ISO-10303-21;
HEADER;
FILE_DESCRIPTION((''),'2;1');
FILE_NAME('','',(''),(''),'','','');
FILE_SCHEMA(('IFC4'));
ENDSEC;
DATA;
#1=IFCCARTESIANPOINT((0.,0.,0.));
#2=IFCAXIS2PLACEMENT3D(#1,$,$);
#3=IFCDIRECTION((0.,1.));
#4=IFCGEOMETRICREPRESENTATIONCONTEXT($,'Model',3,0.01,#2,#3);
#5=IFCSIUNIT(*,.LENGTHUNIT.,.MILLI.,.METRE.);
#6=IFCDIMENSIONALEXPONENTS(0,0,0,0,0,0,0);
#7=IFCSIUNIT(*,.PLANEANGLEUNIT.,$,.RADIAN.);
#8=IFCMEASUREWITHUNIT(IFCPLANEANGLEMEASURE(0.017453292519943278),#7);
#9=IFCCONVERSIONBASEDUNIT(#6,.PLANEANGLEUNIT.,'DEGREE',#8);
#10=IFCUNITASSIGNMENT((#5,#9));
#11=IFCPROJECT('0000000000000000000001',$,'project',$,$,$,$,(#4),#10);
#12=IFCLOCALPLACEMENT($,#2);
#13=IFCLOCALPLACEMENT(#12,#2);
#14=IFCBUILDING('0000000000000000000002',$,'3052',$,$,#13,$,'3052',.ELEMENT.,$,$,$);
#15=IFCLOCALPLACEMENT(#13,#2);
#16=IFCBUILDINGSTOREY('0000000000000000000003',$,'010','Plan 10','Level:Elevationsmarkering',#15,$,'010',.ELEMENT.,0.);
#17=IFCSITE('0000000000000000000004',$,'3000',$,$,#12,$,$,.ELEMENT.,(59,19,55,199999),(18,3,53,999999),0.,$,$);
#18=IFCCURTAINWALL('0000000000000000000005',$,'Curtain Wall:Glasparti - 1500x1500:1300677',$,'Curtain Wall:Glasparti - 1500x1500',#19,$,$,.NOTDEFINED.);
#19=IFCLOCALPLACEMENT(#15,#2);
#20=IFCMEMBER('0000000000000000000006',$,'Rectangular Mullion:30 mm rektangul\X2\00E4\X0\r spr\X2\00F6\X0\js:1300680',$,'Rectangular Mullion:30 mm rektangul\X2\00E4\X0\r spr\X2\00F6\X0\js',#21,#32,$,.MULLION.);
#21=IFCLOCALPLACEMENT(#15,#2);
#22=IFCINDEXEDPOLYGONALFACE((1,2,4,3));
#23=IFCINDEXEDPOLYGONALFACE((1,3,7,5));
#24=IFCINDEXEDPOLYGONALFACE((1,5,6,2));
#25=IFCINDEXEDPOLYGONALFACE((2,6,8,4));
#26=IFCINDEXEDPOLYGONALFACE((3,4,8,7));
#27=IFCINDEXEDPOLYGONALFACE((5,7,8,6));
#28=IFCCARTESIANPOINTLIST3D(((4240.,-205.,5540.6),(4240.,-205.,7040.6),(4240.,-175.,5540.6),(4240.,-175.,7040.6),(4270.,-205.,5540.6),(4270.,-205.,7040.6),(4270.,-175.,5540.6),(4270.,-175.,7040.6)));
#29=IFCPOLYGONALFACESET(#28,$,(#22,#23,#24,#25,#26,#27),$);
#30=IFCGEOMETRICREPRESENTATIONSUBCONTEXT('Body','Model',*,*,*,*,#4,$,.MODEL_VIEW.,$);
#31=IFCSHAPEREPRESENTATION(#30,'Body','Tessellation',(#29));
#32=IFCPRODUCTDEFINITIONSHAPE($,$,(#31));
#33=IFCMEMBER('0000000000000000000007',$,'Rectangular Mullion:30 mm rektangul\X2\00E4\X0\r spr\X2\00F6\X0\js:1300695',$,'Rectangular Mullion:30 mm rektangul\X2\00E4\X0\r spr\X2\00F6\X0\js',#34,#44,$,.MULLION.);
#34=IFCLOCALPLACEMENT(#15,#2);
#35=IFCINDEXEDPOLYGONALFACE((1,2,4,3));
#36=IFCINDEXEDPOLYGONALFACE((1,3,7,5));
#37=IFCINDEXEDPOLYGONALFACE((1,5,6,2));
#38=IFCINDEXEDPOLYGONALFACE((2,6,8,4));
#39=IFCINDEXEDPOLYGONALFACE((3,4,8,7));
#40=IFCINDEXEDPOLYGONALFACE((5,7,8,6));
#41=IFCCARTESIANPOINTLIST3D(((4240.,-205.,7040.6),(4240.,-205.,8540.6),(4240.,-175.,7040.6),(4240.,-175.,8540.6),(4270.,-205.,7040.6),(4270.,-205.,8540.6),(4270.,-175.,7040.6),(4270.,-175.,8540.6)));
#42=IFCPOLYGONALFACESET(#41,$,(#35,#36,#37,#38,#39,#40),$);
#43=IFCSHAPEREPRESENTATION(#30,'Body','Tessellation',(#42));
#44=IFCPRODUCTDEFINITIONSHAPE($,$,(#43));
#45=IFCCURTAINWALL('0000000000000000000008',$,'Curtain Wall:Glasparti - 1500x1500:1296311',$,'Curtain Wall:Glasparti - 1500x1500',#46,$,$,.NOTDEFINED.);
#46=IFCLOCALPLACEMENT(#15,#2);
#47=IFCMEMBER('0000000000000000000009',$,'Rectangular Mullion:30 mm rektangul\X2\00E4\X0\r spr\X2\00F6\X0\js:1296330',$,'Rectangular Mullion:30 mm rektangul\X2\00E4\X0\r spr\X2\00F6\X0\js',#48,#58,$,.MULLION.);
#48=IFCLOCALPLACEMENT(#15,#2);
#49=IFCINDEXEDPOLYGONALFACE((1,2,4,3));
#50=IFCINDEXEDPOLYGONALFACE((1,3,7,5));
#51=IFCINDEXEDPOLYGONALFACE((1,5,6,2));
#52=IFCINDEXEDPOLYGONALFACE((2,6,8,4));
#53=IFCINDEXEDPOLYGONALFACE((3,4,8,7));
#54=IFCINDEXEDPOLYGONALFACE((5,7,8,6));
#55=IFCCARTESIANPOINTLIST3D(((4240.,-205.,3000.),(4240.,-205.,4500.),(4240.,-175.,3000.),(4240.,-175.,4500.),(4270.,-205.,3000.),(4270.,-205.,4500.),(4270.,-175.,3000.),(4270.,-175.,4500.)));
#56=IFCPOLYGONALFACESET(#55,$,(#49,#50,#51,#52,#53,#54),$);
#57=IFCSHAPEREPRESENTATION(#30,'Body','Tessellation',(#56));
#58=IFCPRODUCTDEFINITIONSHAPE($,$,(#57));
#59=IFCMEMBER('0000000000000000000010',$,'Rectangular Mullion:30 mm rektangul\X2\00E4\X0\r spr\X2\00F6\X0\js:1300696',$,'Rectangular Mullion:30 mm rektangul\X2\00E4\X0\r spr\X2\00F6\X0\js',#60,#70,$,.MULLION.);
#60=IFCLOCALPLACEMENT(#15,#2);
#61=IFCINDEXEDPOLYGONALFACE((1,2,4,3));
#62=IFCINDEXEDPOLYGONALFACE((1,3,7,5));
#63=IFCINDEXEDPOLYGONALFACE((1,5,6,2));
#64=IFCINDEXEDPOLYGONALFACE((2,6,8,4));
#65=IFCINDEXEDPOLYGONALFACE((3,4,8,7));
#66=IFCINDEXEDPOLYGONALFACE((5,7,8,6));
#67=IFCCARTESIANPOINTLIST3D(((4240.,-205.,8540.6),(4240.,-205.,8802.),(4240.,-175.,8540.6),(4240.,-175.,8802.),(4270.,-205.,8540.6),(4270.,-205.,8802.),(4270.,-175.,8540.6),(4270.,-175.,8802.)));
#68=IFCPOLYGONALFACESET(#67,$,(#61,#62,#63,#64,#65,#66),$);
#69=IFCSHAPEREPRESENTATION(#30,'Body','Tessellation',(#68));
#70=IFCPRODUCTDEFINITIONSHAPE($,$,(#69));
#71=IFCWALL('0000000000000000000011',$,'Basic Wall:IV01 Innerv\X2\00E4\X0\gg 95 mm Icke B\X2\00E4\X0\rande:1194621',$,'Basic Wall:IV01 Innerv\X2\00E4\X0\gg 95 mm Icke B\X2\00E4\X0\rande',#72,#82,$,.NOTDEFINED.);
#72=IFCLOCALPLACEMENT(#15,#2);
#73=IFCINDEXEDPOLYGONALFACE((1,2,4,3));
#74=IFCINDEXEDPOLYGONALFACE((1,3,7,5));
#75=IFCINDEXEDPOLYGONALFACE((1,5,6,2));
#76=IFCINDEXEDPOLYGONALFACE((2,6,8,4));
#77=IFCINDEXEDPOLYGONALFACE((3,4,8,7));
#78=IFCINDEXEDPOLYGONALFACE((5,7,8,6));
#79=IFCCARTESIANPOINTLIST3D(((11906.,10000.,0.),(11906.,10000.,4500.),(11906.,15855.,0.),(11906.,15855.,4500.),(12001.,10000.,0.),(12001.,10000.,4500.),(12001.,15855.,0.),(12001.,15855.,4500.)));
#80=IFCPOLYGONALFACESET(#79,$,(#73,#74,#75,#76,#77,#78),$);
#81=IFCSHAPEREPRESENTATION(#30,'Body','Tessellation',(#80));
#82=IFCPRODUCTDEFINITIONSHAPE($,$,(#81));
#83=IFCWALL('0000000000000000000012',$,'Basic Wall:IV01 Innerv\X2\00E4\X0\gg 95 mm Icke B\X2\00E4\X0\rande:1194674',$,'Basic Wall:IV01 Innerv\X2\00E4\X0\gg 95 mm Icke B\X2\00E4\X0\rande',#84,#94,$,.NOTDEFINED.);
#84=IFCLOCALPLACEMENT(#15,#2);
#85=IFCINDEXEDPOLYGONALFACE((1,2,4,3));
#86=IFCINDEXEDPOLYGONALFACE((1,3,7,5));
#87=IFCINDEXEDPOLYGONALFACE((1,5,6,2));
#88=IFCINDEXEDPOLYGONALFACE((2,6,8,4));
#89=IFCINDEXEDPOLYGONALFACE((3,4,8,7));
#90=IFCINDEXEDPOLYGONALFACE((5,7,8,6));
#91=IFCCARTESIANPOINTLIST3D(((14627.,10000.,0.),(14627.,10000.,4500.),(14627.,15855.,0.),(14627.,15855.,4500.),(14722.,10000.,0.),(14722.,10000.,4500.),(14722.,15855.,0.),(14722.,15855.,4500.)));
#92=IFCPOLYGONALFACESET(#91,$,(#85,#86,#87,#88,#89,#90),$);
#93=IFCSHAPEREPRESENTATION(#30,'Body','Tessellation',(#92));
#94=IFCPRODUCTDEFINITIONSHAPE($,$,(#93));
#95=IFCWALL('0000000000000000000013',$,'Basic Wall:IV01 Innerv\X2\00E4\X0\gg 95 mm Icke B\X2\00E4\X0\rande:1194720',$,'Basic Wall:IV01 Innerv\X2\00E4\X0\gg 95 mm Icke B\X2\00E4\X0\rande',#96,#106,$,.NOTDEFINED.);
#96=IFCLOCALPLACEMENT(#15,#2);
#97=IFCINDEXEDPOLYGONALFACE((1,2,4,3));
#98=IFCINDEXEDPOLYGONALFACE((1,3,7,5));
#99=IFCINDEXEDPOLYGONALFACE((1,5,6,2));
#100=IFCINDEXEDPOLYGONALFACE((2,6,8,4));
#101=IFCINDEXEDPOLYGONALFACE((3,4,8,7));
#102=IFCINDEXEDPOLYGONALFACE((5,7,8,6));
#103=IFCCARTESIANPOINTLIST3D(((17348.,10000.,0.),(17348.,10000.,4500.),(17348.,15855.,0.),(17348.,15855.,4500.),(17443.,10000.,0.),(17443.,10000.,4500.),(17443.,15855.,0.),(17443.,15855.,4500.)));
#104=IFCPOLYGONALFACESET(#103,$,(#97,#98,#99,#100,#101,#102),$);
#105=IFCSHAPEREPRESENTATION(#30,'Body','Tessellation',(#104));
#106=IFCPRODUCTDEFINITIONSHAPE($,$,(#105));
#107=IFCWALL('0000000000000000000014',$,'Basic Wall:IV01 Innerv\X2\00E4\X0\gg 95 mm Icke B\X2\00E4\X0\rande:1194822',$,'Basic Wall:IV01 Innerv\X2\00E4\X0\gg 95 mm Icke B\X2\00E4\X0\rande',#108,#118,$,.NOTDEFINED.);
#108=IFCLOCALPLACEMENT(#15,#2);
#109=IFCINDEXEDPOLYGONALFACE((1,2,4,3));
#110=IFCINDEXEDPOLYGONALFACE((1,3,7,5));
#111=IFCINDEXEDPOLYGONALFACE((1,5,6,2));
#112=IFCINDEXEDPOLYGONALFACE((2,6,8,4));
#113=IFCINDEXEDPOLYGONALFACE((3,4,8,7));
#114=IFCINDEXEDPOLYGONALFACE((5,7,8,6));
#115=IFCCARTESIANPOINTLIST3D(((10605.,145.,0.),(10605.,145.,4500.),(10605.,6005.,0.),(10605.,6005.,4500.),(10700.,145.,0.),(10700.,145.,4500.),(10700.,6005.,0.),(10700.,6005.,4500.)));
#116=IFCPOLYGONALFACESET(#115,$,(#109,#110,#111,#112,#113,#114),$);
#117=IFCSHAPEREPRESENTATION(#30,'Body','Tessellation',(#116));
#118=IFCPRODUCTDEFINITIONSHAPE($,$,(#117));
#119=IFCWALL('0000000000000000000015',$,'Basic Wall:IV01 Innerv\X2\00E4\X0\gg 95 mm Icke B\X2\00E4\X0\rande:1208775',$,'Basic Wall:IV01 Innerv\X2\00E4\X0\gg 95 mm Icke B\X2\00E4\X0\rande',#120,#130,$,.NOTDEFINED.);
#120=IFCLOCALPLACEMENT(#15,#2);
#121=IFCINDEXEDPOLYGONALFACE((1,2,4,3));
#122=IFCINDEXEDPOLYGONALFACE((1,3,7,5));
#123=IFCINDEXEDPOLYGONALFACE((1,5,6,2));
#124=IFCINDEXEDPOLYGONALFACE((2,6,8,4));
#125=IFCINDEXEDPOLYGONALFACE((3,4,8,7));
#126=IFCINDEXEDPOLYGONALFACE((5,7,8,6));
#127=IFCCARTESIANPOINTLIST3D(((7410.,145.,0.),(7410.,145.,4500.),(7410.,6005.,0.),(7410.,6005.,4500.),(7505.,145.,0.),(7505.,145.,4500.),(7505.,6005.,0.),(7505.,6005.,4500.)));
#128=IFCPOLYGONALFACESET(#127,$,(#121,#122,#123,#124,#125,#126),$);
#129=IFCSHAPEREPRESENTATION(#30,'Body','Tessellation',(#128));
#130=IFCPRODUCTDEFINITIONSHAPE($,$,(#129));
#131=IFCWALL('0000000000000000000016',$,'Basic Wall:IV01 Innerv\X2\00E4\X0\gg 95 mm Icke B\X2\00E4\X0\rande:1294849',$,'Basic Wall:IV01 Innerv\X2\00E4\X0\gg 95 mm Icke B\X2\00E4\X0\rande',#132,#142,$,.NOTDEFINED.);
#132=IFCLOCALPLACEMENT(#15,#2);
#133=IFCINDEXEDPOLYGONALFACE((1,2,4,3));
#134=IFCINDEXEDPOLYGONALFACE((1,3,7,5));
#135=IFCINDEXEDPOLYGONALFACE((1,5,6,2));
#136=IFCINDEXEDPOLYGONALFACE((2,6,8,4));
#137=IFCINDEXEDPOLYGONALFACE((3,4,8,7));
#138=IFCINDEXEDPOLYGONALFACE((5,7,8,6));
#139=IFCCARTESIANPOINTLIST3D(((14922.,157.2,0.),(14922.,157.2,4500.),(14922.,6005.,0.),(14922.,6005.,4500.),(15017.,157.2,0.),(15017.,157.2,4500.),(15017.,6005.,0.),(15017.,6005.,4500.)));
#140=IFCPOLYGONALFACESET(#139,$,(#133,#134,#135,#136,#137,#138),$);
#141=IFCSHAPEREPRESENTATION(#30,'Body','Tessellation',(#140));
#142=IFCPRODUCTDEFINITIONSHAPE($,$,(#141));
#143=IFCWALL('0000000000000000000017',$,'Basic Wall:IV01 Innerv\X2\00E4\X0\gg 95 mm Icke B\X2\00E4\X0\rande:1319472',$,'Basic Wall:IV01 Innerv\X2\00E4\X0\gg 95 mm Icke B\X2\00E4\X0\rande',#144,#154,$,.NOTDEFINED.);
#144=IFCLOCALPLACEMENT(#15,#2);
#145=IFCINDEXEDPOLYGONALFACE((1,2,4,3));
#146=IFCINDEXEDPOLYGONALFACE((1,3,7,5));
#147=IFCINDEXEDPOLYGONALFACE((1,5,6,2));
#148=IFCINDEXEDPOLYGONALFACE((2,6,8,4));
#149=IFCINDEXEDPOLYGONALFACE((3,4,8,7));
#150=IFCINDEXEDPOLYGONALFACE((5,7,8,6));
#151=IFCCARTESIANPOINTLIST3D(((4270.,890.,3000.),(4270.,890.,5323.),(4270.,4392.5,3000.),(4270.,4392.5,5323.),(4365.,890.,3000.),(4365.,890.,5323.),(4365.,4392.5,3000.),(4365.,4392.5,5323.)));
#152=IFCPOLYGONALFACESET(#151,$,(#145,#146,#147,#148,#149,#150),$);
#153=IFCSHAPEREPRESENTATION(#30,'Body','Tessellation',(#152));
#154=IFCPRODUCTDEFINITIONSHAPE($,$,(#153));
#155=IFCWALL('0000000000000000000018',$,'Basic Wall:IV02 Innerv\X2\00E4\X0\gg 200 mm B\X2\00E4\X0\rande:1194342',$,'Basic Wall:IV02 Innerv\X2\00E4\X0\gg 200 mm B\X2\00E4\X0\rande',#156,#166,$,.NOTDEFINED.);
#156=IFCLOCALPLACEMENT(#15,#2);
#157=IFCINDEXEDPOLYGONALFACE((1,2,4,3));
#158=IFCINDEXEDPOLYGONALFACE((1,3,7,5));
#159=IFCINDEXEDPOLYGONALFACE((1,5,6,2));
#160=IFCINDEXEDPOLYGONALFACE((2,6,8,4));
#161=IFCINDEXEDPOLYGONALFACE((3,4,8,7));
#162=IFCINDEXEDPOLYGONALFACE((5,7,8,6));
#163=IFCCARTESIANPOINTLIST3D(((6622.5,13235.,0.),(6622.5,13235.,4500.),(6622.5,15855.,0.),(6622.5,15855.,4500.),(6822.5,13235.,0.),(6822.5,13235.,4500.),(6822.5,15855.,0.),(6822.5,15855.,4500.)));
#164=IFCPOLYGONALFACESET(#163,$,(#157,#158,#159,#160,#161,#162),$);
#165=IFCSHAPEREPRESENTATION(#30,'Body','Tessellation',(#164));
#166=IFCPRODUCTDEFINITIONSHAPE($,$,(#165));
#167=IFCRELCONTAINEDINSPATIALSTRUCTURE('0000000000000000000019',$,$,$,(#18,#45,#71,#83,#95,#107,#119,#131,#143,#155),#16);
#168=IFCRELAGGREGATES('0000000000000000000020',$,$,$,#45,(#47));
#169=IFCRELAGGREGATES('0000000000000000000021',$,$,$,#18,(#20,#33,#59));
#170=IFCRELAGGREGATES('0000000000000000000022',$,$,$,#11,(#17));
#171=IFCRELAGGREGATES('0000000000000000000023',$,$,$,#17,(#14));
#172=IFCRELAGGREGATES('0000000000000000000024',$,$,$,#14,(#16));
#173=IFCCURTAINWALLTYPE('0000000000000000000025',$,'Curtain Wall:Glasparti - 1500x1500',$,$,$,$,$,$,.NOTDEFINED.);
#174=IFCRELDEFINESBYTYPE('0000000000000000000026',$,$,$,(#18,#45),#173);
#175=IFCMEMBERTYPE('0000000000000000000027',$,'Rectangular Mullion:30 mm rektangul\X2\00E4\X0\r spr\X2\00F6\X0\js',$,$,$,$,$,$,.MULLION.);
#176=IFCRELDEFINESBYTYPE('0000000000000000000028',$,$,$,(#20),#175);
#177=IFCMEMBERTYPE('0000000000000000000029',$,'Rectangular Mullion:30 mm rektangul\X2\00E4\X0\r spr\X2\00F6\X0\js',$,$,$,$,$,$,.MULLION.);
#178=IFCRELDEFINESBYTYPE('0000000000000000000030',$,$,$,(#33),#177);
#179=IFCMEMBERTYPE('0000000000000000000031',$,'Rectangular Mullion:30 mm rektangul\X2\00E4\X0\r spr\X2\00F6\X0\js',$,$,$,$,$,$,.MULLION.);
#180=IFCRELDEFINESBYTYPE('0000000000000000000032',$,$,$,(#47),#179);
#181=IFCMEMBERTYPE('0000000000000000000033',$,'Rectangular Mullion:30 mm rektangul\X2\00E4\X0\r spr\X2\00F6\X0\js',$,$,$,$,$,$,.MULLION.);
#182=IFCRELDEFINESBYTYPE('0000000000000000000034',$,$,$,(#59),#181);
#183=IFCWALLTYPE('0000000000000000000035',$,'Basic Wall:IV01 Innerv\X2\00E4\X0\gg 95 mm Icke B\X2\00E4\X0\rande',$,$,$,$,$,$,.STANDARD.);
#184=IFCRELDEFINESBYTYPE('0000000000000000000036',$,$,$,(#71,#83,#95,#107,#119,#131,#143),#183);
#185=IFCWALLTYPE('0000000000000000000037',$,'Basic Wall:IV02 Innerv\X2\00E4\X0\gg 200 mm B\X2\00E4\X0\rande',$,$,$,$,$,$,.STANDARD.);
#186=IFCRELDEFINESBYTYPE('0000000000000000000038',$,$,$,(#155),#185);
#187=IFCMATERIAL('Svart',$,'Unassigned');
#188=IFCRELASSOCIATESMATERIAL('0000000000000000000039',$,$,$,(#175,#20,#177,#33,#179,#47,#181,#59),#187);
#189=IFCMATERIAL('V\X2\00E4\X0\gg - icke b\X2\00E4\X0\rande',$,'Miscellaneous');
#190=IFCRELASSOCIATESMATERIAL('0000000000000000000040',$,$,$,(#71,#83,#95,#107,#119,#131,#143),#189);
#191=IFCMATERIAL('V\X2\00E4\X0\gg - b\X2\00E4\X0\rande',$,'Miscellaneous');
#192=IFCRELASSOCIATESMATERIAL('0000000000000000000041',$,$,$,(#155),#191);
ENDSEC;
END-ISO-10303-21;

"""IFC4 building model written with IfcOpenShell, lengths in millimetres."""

from ifc_helpers import new_model, entity, si_unit, converted_unit, direction, frame, origin, place, context, subcontext, project, spatial, indexed_curve, outline, extrude, source, transform, mapped, material, type_object, type_shapes, element, aggregate, save


model = new_model("IFC4")

# Units and contexts
model_context = context("Model", 3, precision=0.01, world=origin(), true_north=direction((0.0, 1.0)))
body_context = subcontext(model_context, "Body", "Model", "MODEL_VIEW")
ifc_project = project(units=[si_unit("LENGTHUNIT", "METRE", prefix="MILLI"), converted_unit("PLANEANGLEUNIT", "DEGREE", entity("IfcPlaneAngleMeasure", 0.017453292519943278), si_unit("PLANEANGLEUNIT", "RADIAN"), dimensions=[0, 0, 0, 0, 0, 0, 0])], contexts=[model_context])

# Site, building, storey
site_placement = place(None, origin())
site = spatial("IfcSite", under=ifc_project, at=site_placement, Name="3000", CompositionType="ELEMENT", RefLatitude=(59, 19, 55, 199999), RefLongitude=(18, 3, 53, 999999), RefElevation=0.0)
building_placement = place(site_placement, origin())
building = spatial("IfcBuilding", under=site, at=building_placement, Name="3052", LongName="3052", CompositionType="ELEMENT")
storey_placement = place(building_placement, origin())
storey = spatial("IfcBuildingStorey", under=building, at=storey_placement, Name="010", Description="Plan 10", ObjectType="Level:Elevationsmarkering", LongName="010", CompositionType="ELEMENT", Elevation=0.0)

# Curtain wall, members
curtain_wall_type = type_object("IfcCurtainWallType", Name="Curtain Wall:Glasparti - 1500x1500", PredefinedType="NOTDEFINED")
curtain_wall_1_placement = place(storey_placement, origin())
curtain_wall_1 = element("IfcCurtainWall", 1, at=curtain_wall_1_placement, inside=storey, type_object=curtain_wall_type, Name="Curtain Wall:Glasparti - 1500x1500:1300677", ObjectType="Curtain Wall:Glasparti - 1500x1500", PredefinedType="NOTDEFINED")
ifc_material_1 = material(Name="Svart", Category="Unassigned")
member_type_1 = type_object("IfcMemberType", Name="Rectangular Mullion:30 mm rektangulär spröjs", PredefinedType="MULLION", material=ifc_material_1)
shared_shape_1 = source(origin(), body_context, "Body", "SweptSolid", [
    extrude(outline(indexed_curve([(-15.0, -15.0), (15.0, -15.0), (15.0, 15.0), (-15.0, 15.0), (-15.0, -15.0)], self_intersect=False)), frame((-15.0, 0.0, -1500.0), z_axis=(0.0, 0.0, 1.0), x_axis=(-1.0, 0.0, 0.0)), (0.0, 0.0, 1.0), 1500.0),
])
type_shapes(member_type_1, [shared_shape_1])
member_1_placement = place(curtain_wall_1_placement, frame((4270.0, -190.0, 5540.6), z_axis=(0.0, 0.0, -1.0), x_axis=(1.0, 0.0, 0.0)))
member_1 = element("IfcMember", 2, at=member_1_placement, type_object=member_type_1, material=ifc_material_1, Name="Rectangular Mullion:30 mm rektangulär spröjs:1300680", ObjectType="Rectangular Mullion:30 mm rektangulär spröjs", PredefinedType="MULLION", context=body_context, shape_type="MappedRepresentation", body=[
    mapped(shared_shape_1, transform((0.0, 0.0, 0.0), scale=1.0)),
])
member_type_2 = type_object("IfcMemberType", Name="Rectangular Mullion:30 mm rektangulär spröjs", PredefinedType="MULLION", material=ifc_material_1)
shared_shape_2 = source(origin(), body_context, "Body", "SweptSolid", [
    extrude(outline(indexed_curve([(-15.0, -15.0), (15.0, -15.0), (15.0, 15.0), (-15.0, 15.0), (-15.0, -15.0)], self_intersect=False)), frame((-15.0, 0.0, -1500.0), z_axis=(0.0, 0.0, 1.0), x_axis=(-1.0, 0.0, 0.0)), (0.0, 0.0, 1.0), 1500.0),
])
type_shapes(member_type_2, [shared_shape_2])
member_2_placement = place(curtain_wall_1_placement, frame((4270.0, -190.0, 7040.6), z_axis=(0.0, 0.0, -1.0), x_axis=(1.0, 0.0, 0.0)))
member_2 = element("IfcMember", 3, at=member_2_placement, type_object=member_type_2, material=ifc_material_1, Name="Rectangular Mullion:30 mm rektangulär spröjs:1300695", ObjectType="Rectangular Mullion:30 mm rektangulär spröjs", PredefinedType="MULLION", context=body_context, shape_type="MappedRepresentation", body=[
    mapped(shared_shape_2, transform((0.0, 0.0, 0.0), scale=1.0)),
])

# Curtain wall, member
curtain_wall_2_placement = place(storey_placement, origin())
curtain_wall_2 = element("IfcCurtainWall", 4, at=curtain_wall_2_placement, inside=storey, type_object=curtain_wall_type, Name="Curtain Wall:Glasparti - 1500x1500:1296311", ObjectType="Curtain Wall:Glasparti - 1500x1500", PredefinedType="NOTDEFINED")
member_type_3 = type_object("IfcMemberType", Name="Rectangular Mullion:30 mm rektangulär spröjs", PredefinedType="MULLION", material=ifc_material_1)
shared_shape_3 = source(origin(), body_context, "Body", "SweptSolid", [
    extrude(outline(indexed_curve([(-15.0, -15.0), (15.0, -15.0), (15.0, 15.0), (-15.0, 15.0), (-15.0, -15.0)], self_intersect=False)), frame((-15.0, 0.0, -1500.0), z_axis=(0.0, 0.0, 1.0), x_axis=(-1.0, 0.0, 0.0)), (0.0, 0.0, 1.0), 1500.0),
])
type_shapes(member_type_3, [shared_shape_3])
member_3_placement = place(curtain_wall_2_placement, frame((4270.0, -190.0, 3000.0), z_axis=(0.0, 0.0, -1.0), x_axis=(1.0, 0.0, 0.0)))
member_3 = element("IfcMember", 5, at=member_3_placement, type_object=member_type_3, material=ifc_material_1, Name="Rectangular Mullion:30 mm rektangulär spröjs:1296330", ObjectType="Rectangular Mullion:30 mm rektangulär spröjs", PredefinedType="MULLION", context=body_context, shape_type="MappedRepresentation", body=[
    mapped(shared_shape_3, transform((0.0, 0.0, 0.0), scale=1.0)),
])
aggregate(curtain_wall_2, [member_3])

# Member
member_type_4 = type_object("IfcMemberType", Name="Rectangular Mullion:30 mm rektangulär spröjs", PredefinedType="MULLION", material=ifc_material_1)
shared_shape_4 = source(origin(), body_context, "Body", "SweptSolid", [
    extrude(outline(indexed_curve([(-15.0, -15.0), (15.0, -15.0), (15.0, 15.0), (-15.0, 15.0), (-15.0, -15.0)], self_intersect=False)), frame((-15.0, 0.0, -261.4), z_axis=(0.0, 0.0, 1.0), x_axis=(-1.0, 0.0, 0.0)), (0.0, 0.0, 1.0), 261.4),
])
type_shapes(member_type_4, [shared_shape_4])
member_4_placement = place(curtain_wall_1_placement, frame((4270.0, -190.0, 8540.6), z_axis=(0.0, 0.0, -1.0), x_axis=(1.0, 0.0, 0.0)))
member_4 = element("IfcMember", 6, at=member_4_placement, type_object=member_type_4, material=ifc_material_1, Name="Rectangular Mullion:30 mm rektangulär spröjs:1300696", ObjectType="Rectangular Mullion:30 mm rektangulär spröjs", PredefinedType="MULLION", context=body_context, shape_type="MappedRepresentation", body=[
    mapped(shared_shape_4, transform((0.0, 0.0, 0.0), scale=1.0)),
])
aggregate(curtain_wall_1, [member_1, member_2, member_4])

# Walls
ifc_material_2 = material(Name="Vägg - icke bärande", Category="Miscellaneous")
wall_type_1 = type_object("IfcWallType", Name="Basic Wall:IV01 Innervägg 95 mm Icke Bärande", PredefinedType="STANDARD")
wall_1_placement = place(storey_placement, frame((11953.5, 15855.0, 0.0), z_axis=(0.0, 0.0, 1.0), x_axis=(0.0, -1.0, 0.0)))
element("IfcWall", 7, at=wall_1_placement, inside=storey, type_object=wall_type_1, material=ifc_material_2, Name="Basic Wall:IV01 Innervägg 95 mm Icke Bärande:1194621", ObjectType="Basic Wall:IV01 Innervägg 95 mm Icke Bärande", PredefinedType="NOTDEFINED", context=body_context, shape_type="SweptSolid", body=[
    extrude(outline(indexed_curve([(5855.0, 47.5), (0.0, 47.5), (0.0, -47.5), (5855.0, -47.5), (5855.0, 47.5)], self_intersect=False)), origin(), (0.0, 0.0, 1.0), 4500.0),
])
wall_2_placement = place(storey_placement, frame((14674.5, 15855.0, 0.0), z_axis=(0.0, 0.0, 1.0), x_axis=(0.0, -1.0, 0.0)))
element("IfcWall", 8, at=wall_2_placement, inside=storey, type_object=wall_type_1, material=ifc_material_2, Name="Basic Wall:IV01 Innervägg 95 mm Icke Bärande:1194674", ObjectType="Basic Wall:IV01 Innervägg 95 mm Icke Bärande", PredefinedType="NOTDEFINED", context=body_context, shape_type="SweptSolid", body=[
    extrude(outline(indexed_curve([(5855.0, 47.5), (0.0, 47.5), (0.0, -47.5), (5855.0, -47.5), (5855.0, 47.5)], self_intersect=False)), origin(), (0.0, 0.0, 1.0), 4500.0),
])
wall_3_placement = place(storey_placement, frame((17395.5, 15855.0, 0.0), z_axis=(0.0, 0.0, 1.0), x_axis=(0.0, -1.0, 0.0)))
element("IfcWall", 9, at=wall_3_placement, inside=storey, type_object=wall_type_1, material=ifc_material_2, Name="Basic Wall:IV01 Innervägg 95 mm Icke Bärande:1194720", ObjectType="Basic Wall:IV01 Innervägg 95 mm Icke Bärande", PredefinedType="NOTDEFINED", context=body_context, shape_type="SweptSolid", body=[
    extrude(outline(indexed_curve([(5855.0, 47.5), (0.0, 47.5), (0.0, -47.5), (5855.0, -47.5), (5855.0, 47.5)], self_intersect=False)), origin(), (0.0, 0.0, 1.0), 4500.0),
])
wall_4_placement = place(storey_placement, frame((10652.5, 6005.0, 0.0), z_axis=(0.0, 0.0, 1.0), x_axis=(0.0, -1.0, 0.0)))
element("IfcWall", 10, at=wall_4_placement, inside=storey, type_object=wall_type_1, material=ifc_material_2, Name="Basic Wall:IV01 Innervägg 95 mm Icke Bärande:1194822", ObjectType="Basic Wall:IV01 Innervägg 95 mm Icke Bärande", PredefinedType="NOTDEFINED", context=body_context, shape_type="SweptSolid", body=[
    extrude(outline(indexed_curve([(5860.0, 47.5), (0.0, 47.5), (0.0, -47.5), (5860.0, -47.5), (5860.0, 47.5)], self_intersect=False)), origin(), (0.0, 0.0, 1.0), 4500.0),
])
wall_5_placement = place(storey_placement, frame((7457.5, 6005.0, 0.0), z_axis=(0.0, 0.0, 1.0), x_axis=(0.0, -1.0, 0.0)))
element("IfcWall", 11, at=wall_5_placement, inside=storey, type_object=wall_type_1, material=ifc_material_2, Name="Basic Wall:IV01 Innervägg 95 mm Icke Bärande:1208775", ObjectType="Basic Wall:IV01 Innervägg 95 mm Icke Bärande", PredefinedType="NOTDEFINED", context=body_context, shape_type="SweptSolid", body=[
    extrude(outline(indexed_curve([(5860.0, 47.5), (0.0, 47.5), (0.0, -47.5), (5860.0, -47.5), (5860.0, 47.5)], self_intersect=False)), origin(), (0.0, 0.0, 1.0), 4500.0),
])
wall_6_placement = place(storey_placement, frame((14969.5, 6005.0, 0.0), z_axis=(0.0, 0.0, 1.0), x_axis=(0.0, -1.0, 0.0)))
element("IfcWall", 12, at=wall_6_placement, inside=storey, type_object=wall_type_1, material=ifc_material_2, Name="Basic Wall:IV01 Innervägg 95 mm Icke Bärande:1294849", ObjectType="Basic Wall:IV01 Innervägg 95 mm Icke Bärande", PredefinedType="NOTDEFINED", context=body_context, shape_type="SweptSolid", body=[
    extrude(outline(indexed_curve([(5847.8, 47.5), (0.0, 47.5), (0.0, -47.5), (5847.8, -47.5), (5847.8, 47.5)], self_intersect=False)), origin(), (0.0, 0.0, 1.0), 4500.0),
])
wall_7_placement = place(storey_placement, frame((4317.5, 4392.5, 3000.0), z_axis=(0.0, 0.0, 1.0), x_axis=(0.0, -1.0, 0.0)))
element("IfcWall", 13, at=wall_7_placement, inside=storey, type_object=wall_type_1, material=ifc_material_2, Name="Basic Wall:IV01 Innervägg 95 mm Icke Bärande:1319472", ObjectType="Basic Wall:IV01 Innervägg 95 mm Icke Bärande", PredefinedType="NOTDEFINED", context=body_context, shape_type="SweptSolid", body=[
    extrude(outline(indexed_curve([(3502.5, 47.5), (0.0, 47.5), (0.0, -47.5), (3502.5, -47.5), (3502.5, 47.5)], self_intersect=False)), origin(), (0.0, 0.0, 1.0), 2323.0),
])
ifc_material_3 = material(Name="Vägg - bärande", Category="Miscellaneous")
wall_type_2 = type_object("IfcWallType", Name="Basic Wall:IV02 Innervägg 200 mm Bärande", PredefinedType="STANDARD")
wall_8_placement = place(storey_placement, frame((6722.5, 13235.0, 0.0), z_axis=(0.0, 0.0, 1.0), x_axis=(0.0, 1.0, 0.0)))
element("IfcWall", 14, at=wall_8_placement, inside=storey, type_object=wall_type_2, material=ifc_material_3, Name="Basic Wall:IV02 Innervägg 200 mm Bärande:1194342", ObjectType="Basic Wall:IV02 Innervägg 200 mm Bärande", PredefinedType="NOTDEFINED", context=body_context, shape_type="SweptSolid", body=[
    extrude(outline(indexed_curve([(2620.0, 100.0), (0.0, 100.0), (0.0, -100.0), (2620.0, -100.0), (2620.0, 100.0)], self_intersect=False)), origin(), (0.0, 0.0, 1.0), 4500.0),
])

save(model, "model.ifc")
